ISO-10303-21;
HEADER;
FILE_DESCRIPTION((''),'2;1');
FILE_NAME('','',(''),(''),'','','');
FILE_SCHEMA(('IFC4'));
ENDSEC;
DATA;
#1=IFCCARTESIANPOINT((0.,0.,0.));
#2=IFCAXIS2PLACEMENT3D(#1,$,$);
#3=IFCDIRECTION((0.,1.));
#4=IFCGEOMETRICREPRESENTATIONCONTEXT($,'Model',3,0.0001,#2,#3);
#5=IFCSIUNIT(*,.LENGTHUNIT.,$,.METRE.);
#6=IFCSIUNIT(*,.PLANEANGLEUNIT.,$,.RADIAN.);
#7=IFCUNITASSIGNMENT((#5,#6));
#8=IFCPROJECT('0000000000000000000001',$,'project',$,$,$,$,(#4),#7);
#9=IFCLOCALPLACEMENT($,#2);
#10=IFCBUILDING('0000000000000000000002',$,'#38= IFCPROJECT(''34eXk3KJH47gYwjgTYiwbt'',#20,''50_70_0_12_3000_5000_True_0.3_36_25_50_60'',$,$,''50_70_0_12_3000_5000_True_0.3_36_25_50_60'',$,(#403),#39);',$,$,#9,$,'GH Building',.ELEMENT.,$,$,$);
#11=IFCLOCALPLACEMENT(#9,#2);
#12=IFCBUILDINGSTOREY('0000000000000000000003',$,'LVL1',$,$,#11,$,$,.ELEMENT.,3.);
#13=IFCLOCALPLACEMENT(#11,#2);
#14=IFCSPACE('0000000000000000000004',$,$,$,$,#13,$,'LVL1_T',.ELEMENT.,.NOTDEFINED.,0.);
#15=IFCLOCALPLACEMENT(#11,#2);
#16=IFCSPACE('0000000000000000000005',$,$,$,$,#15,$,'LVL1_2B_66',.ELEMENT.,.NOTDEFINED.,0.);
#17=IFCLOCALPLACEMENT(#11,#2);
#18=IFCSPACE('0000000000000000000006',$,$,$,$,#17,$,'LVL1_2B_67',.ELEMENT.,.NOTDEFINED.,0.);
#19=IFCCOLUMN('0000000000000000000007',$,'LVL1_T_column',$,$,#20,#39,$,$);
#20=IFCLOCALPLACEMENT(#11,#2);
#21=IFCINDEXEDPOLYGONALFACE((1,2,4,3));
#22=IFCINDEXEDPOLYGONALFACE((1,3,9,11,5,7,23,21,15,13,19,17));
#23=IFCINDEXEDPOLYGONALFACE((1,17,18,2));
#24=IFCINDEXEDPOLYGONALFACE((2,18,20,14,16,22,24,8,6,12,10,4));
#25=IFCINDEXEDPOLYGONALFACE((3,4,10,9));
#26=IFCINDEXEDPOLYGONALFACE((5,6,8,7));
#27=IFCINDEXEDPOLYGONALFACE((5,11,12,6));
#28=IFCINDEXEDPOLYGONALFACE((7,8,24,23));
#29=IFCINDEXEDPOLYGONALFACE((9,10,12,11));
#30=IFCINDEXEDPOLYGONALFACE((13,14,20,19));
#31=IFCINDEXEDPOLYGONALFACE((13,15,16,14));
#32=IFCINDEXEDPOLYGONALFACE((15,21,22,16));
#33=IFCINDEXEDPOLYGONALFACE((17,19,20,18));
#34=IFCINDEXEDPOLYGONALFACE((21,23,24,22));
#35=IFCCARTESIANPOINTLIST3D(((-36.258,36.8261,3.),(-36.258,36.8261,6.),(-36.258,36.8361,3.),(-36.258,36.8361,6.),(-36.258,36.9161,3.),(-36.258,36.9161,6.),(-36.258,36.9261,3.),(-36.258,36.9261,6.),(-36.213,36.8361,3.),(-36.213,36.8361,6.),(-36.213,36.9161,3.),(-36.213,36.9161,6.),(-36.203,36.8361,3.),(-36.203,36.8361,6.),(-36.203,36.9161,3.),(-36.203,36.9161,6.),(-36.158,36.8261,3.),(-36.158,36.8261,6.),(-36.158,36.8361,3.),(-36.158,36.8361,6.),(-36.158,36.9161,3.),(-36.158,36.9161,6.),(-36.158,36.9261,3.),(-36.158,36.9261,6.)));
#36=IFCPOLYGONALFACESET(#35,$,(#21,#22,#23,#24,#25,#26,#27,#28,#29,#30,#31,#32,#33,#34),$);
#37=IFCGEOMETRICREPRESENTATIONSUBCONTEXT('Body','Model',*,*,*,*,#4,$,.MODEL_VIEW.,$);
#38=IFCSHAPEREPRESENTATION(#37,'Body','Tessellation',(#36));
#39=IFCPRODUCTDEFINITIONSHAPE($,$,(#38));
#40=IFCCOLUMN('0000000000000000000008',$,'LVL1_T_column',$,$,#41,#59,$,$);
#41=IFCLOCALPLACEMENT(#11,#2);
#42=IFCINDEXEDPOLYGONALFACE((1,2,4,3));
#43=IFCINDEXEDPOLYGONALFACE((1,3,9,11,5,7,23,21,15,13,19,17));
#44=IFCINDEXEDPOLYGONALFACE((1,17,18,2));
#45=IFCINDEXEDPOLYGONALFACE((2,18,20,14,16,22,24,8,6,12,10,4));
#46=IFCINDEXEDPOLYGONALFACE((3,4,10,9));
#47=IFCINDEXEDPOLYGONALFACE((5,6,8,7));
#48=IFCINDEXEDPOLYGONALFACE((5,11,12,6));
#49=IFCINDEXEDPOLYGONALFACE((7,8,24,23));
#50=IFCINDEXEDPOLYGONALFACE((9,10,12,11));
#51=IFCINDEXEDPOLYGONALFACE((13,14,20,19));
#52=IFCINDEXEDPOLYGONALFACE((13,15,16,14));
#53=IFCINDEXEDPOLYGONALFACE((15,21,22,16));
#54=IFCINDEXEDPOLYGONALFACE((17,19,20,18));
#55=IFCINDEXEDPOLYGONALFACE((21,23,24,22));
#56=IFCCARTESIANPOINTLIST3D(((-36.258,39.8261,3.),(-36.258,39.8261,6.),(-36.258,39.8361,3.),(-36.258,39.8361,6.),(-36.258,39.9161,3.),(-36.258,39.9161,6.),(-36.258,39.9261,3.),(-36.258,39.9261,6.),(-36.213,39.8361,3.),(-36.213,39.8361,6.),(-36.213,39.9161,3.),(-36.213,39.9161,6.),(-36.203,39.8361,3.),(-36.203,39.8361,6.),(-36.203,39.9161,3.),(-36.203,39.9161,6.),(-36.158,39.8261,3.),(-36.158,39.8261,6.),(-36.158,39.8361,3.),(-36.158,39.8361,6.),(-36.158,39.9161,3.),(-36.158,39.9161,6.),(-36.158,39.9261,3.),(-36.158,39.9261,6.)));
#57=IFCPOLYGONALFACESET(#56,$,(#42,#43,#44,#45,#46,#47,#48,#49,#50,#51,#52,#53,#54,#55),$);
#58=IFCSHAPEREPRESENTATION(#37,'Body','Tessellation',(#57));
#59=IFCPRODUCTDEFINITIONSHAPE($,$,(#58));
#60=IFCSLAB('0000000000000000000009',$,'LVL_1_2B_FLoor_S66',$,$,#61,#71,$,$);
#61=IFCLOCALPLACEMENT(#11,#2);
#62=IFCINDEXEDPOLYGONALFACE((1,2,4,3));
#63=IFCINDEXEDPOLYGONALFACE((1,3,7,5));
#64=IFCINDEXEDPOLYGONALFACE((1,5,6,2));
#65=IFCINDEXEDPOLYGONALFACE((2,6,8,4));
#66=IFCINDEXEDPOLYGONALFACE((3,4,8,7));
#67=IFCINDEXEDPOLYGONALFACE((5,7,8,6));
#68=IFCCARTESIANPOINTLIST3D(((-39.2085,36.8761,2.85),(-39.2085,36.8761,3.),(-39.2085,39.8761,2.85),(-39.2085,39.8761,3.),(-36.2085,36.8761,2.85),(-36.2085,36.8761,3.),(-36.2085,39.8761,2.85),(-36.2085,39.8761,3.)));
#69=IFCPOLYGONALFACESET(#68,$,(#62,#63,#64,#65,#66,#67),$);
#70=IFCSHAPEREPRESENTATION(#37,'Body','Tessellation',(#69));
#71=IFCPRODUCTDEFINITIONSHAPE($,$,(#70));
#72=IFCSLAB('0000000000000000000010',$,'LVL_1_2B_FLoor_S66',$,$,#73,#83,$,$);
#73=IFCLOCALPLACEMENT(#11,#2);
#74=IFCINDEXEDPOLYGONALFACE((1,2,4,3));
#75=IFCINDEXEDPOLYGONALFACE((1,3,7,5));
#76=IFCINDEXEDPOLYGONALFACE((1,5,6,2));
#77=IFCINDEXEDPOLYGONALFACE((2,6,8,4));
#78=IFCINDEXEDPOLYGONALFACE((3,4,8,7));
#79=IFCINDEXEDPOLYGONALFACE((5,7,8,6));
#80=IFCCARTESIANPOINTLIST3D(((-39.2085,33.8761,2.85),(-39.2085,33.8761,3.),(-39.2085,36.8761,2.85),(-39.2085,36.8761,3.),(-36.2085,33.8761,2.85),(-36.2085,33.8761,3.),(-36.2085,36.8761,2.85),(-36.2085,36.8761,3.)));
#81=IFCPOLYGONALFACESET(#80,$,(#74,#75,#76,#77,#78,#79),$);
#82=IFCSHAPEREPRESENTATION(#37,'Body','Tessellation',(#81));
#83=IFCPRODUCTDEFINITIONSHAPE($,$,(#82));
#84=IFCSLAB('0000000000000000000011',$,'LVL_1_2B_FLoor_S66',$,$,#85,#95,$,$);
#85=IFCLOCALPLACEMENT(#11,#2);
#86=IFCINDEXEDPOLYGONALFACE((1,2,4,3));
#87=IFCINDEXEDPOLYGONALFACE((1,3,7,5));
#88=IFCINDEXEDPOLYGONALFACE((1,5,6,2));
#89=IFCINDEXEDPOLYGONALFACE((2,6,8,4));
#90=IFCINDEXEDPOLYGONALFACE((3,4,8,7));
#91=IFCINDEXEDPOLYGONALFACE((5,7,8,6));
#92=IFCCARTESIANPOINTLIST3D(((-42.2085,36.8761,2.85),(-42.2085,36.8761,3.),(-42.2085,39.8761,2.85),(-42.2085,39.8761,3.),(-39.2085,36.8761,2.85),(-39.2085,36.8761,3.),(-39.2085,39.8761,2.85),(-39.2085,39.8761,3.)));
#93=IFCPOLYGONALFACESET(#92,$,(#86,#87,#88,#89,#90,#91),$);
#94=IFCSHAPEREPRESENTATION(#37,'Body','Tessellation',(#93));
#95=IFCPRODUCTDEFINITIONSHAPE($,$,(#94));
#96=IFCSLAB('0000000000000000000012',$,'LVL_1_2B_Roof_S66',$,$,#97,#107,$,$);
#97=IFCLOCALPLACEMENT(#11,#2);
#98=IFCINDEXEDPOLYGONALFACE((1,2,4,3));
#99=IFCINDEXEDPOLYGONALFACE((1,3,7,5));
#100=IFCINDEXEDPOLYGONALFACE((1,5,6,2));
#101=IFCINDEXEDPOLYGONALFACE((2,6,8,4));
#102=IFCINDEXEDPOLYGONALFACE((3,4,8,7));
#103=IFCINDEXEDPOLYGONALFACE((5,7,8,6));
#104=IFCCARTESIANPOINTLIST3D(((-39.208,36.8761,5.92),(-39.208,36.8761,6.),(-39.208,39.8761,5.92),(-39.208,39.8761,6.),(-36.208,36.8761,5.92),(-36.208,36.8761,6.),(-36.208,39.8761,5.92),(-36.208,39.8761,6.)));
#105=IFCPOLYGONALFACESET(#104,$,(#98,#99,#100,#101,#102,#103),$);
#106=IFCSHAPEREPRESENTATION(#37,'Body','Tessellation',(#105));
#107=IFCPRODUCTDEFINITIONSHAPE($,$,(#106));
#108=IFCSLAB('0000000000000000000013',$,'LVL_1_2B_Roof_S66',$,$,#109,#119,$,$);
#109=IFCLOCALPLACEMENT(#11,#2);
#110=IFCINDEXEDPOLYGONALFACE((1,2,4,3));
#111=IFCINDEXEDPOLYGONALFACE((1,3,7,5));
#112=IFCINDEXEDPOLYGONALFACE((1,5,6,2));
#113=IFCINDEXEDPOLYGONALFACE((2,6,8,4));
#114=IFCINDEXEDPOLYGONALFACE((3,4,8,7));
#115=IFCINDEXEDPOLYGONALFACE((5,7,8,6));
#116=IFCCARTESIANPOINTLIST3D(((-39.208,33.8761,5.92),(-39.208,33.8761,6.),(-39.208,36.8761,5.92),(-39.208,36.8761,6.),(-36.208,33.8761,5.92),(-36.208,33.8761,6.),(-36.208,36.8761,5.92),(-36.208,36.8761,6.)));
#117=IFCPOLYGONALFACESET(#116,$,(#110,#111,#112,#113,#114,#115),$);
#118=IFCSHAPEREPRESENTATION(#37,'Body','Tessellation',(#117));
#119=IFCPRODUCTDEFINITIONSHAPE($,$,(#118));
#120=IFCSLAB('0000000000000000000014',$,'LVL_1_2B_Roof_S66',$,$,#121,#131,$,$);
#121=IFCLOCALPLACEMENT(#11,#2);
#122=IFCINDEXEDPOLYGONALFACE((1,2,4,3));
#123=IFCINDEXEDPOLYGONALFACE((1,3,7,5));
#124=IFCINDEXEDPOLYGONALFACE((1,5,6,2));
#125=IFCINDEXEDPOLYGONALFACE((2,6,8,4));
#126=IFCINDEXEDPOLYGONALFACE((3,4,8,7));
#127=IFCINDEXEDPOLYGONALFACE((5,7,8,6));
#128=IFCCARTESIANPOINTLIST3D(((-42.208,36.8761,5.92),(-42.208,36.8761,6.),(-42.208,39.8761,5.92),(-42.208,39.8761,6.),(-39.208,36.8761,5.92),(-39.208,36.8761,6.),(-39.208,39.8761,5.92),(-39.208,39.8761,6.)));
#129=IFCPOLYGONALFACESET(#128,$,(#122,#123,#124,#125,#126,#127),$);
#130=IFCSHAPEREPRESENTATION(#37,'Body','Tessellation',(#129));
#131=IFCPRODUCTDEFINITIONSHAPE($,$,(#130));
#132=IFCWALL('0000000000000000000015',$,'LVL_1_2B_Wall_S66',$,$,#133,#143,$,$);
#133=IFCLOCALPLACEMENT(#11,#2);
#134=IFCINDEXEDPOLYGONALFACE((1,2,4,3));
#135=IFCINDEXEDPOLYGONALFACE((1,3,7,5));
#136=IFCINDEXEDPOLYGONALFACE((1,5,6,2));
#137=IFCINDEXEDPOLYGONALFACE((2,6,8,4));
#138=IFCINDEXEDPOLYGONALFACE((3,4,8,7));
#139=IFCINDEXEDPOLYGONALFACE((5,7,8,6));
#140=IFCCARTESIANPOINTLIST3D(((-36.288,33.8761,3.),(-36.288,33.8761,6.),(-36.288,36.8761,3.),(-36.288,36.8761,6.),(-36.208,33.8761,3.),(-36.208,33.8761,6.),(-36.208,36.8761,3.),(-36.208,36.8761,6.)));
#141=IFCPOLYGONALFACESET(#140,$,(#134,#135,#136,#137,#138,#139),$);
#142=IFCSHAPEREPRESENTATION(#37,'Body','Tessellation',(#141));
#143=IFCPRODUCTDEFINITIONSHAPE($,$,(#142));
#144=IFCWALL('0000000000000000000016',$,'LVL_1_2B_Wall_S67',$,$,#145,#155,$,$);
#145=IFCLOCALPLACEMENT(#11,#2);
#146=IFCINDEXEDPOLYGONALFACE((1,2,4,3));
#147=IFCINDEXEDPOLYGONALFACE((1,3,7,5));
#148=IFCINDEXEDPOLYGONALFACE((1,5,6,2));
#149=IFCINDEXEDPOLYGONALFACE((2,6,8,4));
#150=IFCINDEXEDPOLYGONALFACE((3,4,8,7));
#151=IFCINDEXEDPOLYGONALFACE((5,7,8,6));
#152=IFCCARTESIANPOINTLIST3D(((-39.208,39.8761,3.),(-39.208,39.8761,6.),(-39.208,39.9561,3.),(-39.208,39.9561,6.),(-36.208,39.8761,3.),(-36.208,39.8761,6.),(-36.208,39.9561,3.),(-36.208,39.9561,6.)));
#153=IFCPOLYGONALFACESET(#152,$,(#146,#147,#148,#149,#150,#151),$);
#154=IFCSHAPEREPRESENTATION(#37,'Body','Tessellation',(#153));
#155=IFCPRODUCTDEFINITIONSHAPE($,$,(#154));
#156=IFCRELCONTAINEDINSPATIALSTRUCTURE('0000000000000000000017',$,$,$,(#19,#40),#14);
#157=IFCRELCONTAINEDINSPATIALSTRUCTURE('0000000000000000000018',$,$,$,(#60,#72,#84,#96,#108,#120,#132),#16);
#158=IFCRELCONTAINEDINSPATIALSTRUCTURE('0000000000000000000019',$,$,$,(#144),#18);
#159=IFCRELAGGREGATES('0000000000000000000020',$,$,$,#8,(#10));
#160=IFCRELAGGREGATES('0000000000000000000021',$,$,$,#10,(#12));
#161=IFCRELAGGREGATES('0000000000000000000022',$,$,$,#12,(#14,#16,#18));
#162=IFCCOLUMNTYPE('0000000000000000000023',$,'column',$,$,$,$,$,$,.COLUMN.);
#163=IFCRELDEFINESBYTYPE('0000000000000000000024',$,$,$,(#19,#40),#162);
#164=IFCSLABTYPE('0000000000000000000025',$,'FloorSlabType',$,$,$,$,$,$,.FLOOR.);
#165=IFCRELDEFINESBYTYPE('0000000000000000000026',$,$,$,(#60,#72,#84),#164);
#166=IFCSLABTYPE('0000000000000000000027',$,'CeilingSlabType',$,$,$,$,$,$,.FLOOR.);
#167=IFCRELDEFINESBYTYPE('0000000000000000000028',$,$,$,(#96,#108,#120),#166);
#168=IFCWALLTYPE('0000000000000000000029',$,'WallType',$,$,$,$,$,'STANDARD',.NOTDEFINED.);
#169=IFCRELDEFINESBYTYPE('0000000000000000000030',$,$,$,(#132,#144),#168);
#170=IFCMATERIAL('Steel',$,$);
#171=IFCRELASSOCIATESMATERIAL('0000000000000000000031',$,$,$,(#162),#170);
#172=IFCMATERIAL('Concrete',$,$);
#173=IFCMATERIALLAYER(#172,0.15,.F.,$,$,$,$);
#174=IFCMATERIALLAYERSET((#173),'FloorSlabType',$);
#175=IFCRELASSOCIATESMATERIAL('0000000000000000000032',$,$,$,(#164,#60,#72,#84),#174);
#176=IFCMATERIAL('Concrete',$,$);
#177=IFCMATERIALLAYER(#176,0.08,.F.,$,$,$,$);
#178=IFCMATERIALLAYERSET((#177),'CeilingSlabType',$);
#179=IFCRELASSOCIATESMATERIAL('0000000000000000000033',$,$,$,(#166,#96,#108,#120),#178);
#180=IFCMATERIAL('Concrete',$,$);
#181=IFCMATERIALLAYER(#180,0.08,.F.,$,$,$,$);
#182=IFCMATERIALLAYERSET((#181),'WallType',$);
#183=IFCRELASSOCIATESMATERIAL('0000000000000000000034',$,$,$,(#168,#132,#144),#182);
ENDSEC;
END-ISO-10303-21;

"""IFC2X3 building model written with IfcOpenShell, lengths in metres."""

from ifc_helpers import new_model, si_unit, direction, frame, frame_2d, origin, origin_2d, place, context, subcontext, project, spatial, rectangle, i_section, extrude, material, layer, layer_set, layer_usage, type_object, element, save


model = new_model("IFC2X3")

# Units and contexts
model_context = context("Model", 3, precision=0.0001, world=origin(), true_north=direction((0.0, 1.0)))
body_context = subcontext(model_context, "Body", "Model", "MODEL_VIEW")
ifc_project = project(units=[si_unit("LENGTHUNIT", "METRE"), si_unit("PLANEANGLEUNIT", "RADIAN")], contexts=[model_context])

# Building, storey, space
building_placement = place(None, origin())
building = spatial("IfcBuilding", under=ifc_project, at=building_placement, Name="#38= IFCPROJECT('34eXk3KJH47gYwjgTYiwbt',#20,'50_70_0_12_3000_5000_True_0.3_36_25_50_60',$,$,'50_70_0_12_3000_5000_True_0.3_36_25_50_60',$,(#403),#39);", LongName="GH Building", CompositionType="ELEMENT")
storey_placement = place(building_placement, origin())
storey = spatial("IfcBuildingStorey", under=building, at=storey_placement, Name="LVL1", CompositionType="ELEMENT", Elevation=3.0)
space_1_placement = place(storey_placement, origin())
space_1 = spatial("IfcSpace", under=storey, at=space_1_placement, LongName="LVL1_T", CompositionType="ELEMENT", InteriorOrExteriorSpace="NOTDEFINED", ElevationWithFlooring=0.0)

# Columns
ifc_material_1 = material(Name="Steel")
column_type = type_object("IfcColumnType", Name="column", PredefinedType="COLUMN", material=ifc_material_1)
for number, where, name in (
    (1, (-36.208, 36.8761, 3.0), "LVL1_T_column"),
    (2, (-36.208, 39.8761, 3.0), "LVL1_T_column"),
):
    element("IfcColumn", number, at=place(space_1_placement, frame(where)), inside=space_1, type_object=column_type, Name=name, context=body_context, shape_type="SweptSolid", body=[
        extrude(i_section(OverallWidth=0.1, OverallDepth=0.1, WebThickness=0.01, FlangeThickness=0.01, at=origin_2d()), origin(), (0.0, 0.0, 1.0), 3.0),
    ])

# Shared definitions
space_2_placement = place(storey_placement, origin())
space_2 = spatial("IfcSpace", under=storey, at=space_2_placement, LongName="LVL1_2B_66", CompositionType="ELEMENT", InteriorOrExteriorSpace="NOTDEFINED", ElevationWithFlooring=0.0)

# Slabs
ifc_material_2 = material(Name="Concrete")
ifc_layer_1 = layer(ifc_material_2, 0.15, ventilated=False)
ifc_layer_set_1 = layer_set([ifc_layer_1], Name="FloorSlabType")
ifc_layer_usage_1 = layer_usage(ifc_layer_set_1, "AXIS3", "NEGATIVE", -0.15)
slab_type_1 = type_object("IfcSlabType", Name="FloorSlabType", PredefinedType="FLOOR", material=ifc_layer_set_1)
slab_1_placement = place(space_2_placement, frame((-39.2085, 39.8761, 2.85), z_axis=(0.0, 0.0, 1.0), x_axis=(0.0, -1.0, 0.0)))
element("IfcSlab", 3, at=slab_1_placement, inside=space_2, type_object=slab_type_1, material=ifc_layer_usage_1, Name="LVL_1_2B_FLoor_S66", context=body_context, shape_type="SweptSolid", body=[
    extrude(rectangle(XDim=3.0, YDim=3.0, at=frame_2d((1.5, 1.5))), origin(), (0.0, 0.0, 1.0), 0.15),
])
ifc_layer_usage_2 = layer_usage(ifc_layer_set_1, "AXIS3", "NEGATIVE", -0.15)
slab_2_placement = place(space_2_placement, frame((-39.2085, 36.8761, 2.85), z_axis=(0.0, 0.0, 1.0), x_axis=(0.0, -1.0, 0.0)))
element("IfcSlab", 4, at=slab_2_placement, inside=space_2, type_object=slab_type_1, material=ifc_layer_usage_2, Name="LVL_1_2B_FLoor_S66", context=body_context, shape_type="SweptSolid", body=[
    extrude(rectangle(XDim=3.0, YDim=3.0, at=frame_2d((1.5, 1.5))), origin(), (0.0, 0.0, 1.0), 0.15),
])
ifc_layer_usage_3 = layer_usage(ifc_layer_set_1, "AXIS3", "NEGATIVE", -0.15)
slab_3_placement = place(space_2_placement, frame((-42.2085, 39.8761, 2.85), z_axis=(0.0, 0.0, 1.0), x_axis=(0.0, -1.0, 0.0)))
element("IfcSlab", 5, at=slab_3_placement, inside=space_2, type_object=slab_type_1, material=ifc_layer_usage_3, Name="LVL_1_2B_FLoor_S66", context=body_context, shape_type="SweptSolid", body=[
    extrude(rectangle(XDim=3.0, YDim=3.0, at=frame_2d((1.5, 1.5))), origin(), (0.0, 0.0, 1.0), 0.15),
])
ifc_material_3 = material(Name="Concrete")
ifc_layer_2 = layer(ifc_material_3, 0.08, ventilated=False)
ifc_layer_set_2 = layer_set([ifc_layer_2], Name="CeilingSlabType")
ifc_layer_usage_4 = layer_usage(ifc_layer_set_2, "AXIS3", "NEGATIVE", -0.08)
slab_type_2 = type_object("IfcSlabType", Name="CeilingSlabType", PredefinedType="FLOOR", material=ifc_layer_set_2)
slab_4_placement = place(space_2_placement, frame((-39.208, 39.8761, 5.92), z_axis=(0.0, 0.0, 1.0), x_axis=(0.0, -1.0, 0.0)))
element("IfcSlab", 6, at=slab_4_placement, inside=space_2, type_object=slab_type_2, material=ifc_layer_usage_4, Name="LVL_1_2B_Roof_S66", context=body_context, shape_type="SweptSolid", body=[
    extrude(rectangle(XDim=3.0, YDim=3.0, at=frame_2d((1.5, 1.5))), origin(), (0.0, 0.0, 1.0), 0.08),
])
ifc_layer_usage_5 = layer_usage(ifc_layer_set_2, "AXIS3", "NEGATIVE", -0.08)
slab_5_placement = place(space_2_placement, frame((-39.208, 36.8761, 5.92), z_axis=(0.0, 0.0, 1.0), x_axis=(0.0, -1.0, 0.0)))
element("IfcSlab", 7, at=slab_5_placement, inside=space_2, type_object=slab_type_2, material=ifc_layer_usage_5, Name="LVL_1_2B_Roof_S66", context=body_context, shape_type="SweptSolid", body=[
    extrude(rectangle(XDim=3.0, YDim=3.0, at=frame_2d((1.5, 1.5))), origin(), (0.0, 0.0, 1.0), 0.08),
])
ifc_layer_usage_6 = layer_usage(ifc_layer_set_2, "AXIS3", "NEGATIVE", -0.08)
slab_6_placement = place(space_2_placement, frame((-42.208, 39.8761, 5.92), z_axis=(0.0, 0.0, 1.0), x_axis=(0.0, -1.0, 0.0)))
element("IfcSlab", 8, at=slab_6_placement, inside=space_2, type_object=slab_type_2, material=ifc_layer_usage_6, Name="LVL_1_2B_Roof_S66", context=body_context, shape_type="SweptSolid", body=[
    extrude(rectangle(XDim=3.0, YDim=3.0, at=frame_2d((1.5, 1.5))), origin(), (0.0, 0.0, 1.0), 0.08),
])

# Shared definitions
ifc_material_4 = material(Name="Concrete")
ifc_layer_3 = layer(ifc_material_4, 0.08, ventilated=False)
ifc_layer_set_3 = layer_set([ifc_layer_3], Name="WallType")
wall_type = type_object("IfcWallType", Name="WallType", ElementType="STANDARD", PredefinedType="NOTDEFINED", material=ifc_layer_set_3)

# Shared definitions
space_3_placement = place(storey_placement, origin())
space_3 = spatial("IfcSpace", under=storey, at=space_3_placement, LongName="LVL1_2B_67", CompositionType="ELEMENT", InteriorOrExteriorSpace="NOTDEFINED", ElevationWithFlooring=0.0)

# Walls
ifc_layer_usage_7 = layer_usage(ifc_layer_set_3, "AXIS2", "NEGATIVE", 0.0)
wall_1_placement = place(space_2_placement, frame((-36.208, 36.8761, 3.0), z_axis=(0.0, 0.0, 1.0), x_axis=(0.0, -1.0, 0.0)))
element("IfcWall", 9, at=wall_1_placement, inside=space_2, type_object=wall_type, material=ifc_layer_usage_7, Name="LVL_1_2B_Wall_S66", context=body_context, shape_type="SweptSolid", body=[
    extrude(rectangle(XDim=3.0, YDim=0.08, at=frame_2d((1.5, -0.04))), origin(), (0.0, 0.0, 1.0), 3.0),
])
ifc_layer_usage_8 = layer_usage(ifc_layer_set_3, "AXIS2", "NEGATIVE", 0.0)
wall_2_placement = place(space_3_placement, frame((-36.208, 39.8761, 3.0), z_axis=(0.0, 0.0, 1.0), x_axis=(-1.0, 0.0, 0.0)))
element("IfcWall", 10, at=wall_2_placement, inside=space_3, type_object=wall_type, material=ifc_layer_usage_8, Name="LVL_1_2B_Wall_S67", context=body_context, shape_type="SweptSolid", body=[
    extrude(rectangle(XDim=3.0, YDim=0.08, at=frame_2d((1.5, -0.04))), origin(), (0.0, 0.0, 1.0), 3.0),
])

save(model, "model.ifc")
